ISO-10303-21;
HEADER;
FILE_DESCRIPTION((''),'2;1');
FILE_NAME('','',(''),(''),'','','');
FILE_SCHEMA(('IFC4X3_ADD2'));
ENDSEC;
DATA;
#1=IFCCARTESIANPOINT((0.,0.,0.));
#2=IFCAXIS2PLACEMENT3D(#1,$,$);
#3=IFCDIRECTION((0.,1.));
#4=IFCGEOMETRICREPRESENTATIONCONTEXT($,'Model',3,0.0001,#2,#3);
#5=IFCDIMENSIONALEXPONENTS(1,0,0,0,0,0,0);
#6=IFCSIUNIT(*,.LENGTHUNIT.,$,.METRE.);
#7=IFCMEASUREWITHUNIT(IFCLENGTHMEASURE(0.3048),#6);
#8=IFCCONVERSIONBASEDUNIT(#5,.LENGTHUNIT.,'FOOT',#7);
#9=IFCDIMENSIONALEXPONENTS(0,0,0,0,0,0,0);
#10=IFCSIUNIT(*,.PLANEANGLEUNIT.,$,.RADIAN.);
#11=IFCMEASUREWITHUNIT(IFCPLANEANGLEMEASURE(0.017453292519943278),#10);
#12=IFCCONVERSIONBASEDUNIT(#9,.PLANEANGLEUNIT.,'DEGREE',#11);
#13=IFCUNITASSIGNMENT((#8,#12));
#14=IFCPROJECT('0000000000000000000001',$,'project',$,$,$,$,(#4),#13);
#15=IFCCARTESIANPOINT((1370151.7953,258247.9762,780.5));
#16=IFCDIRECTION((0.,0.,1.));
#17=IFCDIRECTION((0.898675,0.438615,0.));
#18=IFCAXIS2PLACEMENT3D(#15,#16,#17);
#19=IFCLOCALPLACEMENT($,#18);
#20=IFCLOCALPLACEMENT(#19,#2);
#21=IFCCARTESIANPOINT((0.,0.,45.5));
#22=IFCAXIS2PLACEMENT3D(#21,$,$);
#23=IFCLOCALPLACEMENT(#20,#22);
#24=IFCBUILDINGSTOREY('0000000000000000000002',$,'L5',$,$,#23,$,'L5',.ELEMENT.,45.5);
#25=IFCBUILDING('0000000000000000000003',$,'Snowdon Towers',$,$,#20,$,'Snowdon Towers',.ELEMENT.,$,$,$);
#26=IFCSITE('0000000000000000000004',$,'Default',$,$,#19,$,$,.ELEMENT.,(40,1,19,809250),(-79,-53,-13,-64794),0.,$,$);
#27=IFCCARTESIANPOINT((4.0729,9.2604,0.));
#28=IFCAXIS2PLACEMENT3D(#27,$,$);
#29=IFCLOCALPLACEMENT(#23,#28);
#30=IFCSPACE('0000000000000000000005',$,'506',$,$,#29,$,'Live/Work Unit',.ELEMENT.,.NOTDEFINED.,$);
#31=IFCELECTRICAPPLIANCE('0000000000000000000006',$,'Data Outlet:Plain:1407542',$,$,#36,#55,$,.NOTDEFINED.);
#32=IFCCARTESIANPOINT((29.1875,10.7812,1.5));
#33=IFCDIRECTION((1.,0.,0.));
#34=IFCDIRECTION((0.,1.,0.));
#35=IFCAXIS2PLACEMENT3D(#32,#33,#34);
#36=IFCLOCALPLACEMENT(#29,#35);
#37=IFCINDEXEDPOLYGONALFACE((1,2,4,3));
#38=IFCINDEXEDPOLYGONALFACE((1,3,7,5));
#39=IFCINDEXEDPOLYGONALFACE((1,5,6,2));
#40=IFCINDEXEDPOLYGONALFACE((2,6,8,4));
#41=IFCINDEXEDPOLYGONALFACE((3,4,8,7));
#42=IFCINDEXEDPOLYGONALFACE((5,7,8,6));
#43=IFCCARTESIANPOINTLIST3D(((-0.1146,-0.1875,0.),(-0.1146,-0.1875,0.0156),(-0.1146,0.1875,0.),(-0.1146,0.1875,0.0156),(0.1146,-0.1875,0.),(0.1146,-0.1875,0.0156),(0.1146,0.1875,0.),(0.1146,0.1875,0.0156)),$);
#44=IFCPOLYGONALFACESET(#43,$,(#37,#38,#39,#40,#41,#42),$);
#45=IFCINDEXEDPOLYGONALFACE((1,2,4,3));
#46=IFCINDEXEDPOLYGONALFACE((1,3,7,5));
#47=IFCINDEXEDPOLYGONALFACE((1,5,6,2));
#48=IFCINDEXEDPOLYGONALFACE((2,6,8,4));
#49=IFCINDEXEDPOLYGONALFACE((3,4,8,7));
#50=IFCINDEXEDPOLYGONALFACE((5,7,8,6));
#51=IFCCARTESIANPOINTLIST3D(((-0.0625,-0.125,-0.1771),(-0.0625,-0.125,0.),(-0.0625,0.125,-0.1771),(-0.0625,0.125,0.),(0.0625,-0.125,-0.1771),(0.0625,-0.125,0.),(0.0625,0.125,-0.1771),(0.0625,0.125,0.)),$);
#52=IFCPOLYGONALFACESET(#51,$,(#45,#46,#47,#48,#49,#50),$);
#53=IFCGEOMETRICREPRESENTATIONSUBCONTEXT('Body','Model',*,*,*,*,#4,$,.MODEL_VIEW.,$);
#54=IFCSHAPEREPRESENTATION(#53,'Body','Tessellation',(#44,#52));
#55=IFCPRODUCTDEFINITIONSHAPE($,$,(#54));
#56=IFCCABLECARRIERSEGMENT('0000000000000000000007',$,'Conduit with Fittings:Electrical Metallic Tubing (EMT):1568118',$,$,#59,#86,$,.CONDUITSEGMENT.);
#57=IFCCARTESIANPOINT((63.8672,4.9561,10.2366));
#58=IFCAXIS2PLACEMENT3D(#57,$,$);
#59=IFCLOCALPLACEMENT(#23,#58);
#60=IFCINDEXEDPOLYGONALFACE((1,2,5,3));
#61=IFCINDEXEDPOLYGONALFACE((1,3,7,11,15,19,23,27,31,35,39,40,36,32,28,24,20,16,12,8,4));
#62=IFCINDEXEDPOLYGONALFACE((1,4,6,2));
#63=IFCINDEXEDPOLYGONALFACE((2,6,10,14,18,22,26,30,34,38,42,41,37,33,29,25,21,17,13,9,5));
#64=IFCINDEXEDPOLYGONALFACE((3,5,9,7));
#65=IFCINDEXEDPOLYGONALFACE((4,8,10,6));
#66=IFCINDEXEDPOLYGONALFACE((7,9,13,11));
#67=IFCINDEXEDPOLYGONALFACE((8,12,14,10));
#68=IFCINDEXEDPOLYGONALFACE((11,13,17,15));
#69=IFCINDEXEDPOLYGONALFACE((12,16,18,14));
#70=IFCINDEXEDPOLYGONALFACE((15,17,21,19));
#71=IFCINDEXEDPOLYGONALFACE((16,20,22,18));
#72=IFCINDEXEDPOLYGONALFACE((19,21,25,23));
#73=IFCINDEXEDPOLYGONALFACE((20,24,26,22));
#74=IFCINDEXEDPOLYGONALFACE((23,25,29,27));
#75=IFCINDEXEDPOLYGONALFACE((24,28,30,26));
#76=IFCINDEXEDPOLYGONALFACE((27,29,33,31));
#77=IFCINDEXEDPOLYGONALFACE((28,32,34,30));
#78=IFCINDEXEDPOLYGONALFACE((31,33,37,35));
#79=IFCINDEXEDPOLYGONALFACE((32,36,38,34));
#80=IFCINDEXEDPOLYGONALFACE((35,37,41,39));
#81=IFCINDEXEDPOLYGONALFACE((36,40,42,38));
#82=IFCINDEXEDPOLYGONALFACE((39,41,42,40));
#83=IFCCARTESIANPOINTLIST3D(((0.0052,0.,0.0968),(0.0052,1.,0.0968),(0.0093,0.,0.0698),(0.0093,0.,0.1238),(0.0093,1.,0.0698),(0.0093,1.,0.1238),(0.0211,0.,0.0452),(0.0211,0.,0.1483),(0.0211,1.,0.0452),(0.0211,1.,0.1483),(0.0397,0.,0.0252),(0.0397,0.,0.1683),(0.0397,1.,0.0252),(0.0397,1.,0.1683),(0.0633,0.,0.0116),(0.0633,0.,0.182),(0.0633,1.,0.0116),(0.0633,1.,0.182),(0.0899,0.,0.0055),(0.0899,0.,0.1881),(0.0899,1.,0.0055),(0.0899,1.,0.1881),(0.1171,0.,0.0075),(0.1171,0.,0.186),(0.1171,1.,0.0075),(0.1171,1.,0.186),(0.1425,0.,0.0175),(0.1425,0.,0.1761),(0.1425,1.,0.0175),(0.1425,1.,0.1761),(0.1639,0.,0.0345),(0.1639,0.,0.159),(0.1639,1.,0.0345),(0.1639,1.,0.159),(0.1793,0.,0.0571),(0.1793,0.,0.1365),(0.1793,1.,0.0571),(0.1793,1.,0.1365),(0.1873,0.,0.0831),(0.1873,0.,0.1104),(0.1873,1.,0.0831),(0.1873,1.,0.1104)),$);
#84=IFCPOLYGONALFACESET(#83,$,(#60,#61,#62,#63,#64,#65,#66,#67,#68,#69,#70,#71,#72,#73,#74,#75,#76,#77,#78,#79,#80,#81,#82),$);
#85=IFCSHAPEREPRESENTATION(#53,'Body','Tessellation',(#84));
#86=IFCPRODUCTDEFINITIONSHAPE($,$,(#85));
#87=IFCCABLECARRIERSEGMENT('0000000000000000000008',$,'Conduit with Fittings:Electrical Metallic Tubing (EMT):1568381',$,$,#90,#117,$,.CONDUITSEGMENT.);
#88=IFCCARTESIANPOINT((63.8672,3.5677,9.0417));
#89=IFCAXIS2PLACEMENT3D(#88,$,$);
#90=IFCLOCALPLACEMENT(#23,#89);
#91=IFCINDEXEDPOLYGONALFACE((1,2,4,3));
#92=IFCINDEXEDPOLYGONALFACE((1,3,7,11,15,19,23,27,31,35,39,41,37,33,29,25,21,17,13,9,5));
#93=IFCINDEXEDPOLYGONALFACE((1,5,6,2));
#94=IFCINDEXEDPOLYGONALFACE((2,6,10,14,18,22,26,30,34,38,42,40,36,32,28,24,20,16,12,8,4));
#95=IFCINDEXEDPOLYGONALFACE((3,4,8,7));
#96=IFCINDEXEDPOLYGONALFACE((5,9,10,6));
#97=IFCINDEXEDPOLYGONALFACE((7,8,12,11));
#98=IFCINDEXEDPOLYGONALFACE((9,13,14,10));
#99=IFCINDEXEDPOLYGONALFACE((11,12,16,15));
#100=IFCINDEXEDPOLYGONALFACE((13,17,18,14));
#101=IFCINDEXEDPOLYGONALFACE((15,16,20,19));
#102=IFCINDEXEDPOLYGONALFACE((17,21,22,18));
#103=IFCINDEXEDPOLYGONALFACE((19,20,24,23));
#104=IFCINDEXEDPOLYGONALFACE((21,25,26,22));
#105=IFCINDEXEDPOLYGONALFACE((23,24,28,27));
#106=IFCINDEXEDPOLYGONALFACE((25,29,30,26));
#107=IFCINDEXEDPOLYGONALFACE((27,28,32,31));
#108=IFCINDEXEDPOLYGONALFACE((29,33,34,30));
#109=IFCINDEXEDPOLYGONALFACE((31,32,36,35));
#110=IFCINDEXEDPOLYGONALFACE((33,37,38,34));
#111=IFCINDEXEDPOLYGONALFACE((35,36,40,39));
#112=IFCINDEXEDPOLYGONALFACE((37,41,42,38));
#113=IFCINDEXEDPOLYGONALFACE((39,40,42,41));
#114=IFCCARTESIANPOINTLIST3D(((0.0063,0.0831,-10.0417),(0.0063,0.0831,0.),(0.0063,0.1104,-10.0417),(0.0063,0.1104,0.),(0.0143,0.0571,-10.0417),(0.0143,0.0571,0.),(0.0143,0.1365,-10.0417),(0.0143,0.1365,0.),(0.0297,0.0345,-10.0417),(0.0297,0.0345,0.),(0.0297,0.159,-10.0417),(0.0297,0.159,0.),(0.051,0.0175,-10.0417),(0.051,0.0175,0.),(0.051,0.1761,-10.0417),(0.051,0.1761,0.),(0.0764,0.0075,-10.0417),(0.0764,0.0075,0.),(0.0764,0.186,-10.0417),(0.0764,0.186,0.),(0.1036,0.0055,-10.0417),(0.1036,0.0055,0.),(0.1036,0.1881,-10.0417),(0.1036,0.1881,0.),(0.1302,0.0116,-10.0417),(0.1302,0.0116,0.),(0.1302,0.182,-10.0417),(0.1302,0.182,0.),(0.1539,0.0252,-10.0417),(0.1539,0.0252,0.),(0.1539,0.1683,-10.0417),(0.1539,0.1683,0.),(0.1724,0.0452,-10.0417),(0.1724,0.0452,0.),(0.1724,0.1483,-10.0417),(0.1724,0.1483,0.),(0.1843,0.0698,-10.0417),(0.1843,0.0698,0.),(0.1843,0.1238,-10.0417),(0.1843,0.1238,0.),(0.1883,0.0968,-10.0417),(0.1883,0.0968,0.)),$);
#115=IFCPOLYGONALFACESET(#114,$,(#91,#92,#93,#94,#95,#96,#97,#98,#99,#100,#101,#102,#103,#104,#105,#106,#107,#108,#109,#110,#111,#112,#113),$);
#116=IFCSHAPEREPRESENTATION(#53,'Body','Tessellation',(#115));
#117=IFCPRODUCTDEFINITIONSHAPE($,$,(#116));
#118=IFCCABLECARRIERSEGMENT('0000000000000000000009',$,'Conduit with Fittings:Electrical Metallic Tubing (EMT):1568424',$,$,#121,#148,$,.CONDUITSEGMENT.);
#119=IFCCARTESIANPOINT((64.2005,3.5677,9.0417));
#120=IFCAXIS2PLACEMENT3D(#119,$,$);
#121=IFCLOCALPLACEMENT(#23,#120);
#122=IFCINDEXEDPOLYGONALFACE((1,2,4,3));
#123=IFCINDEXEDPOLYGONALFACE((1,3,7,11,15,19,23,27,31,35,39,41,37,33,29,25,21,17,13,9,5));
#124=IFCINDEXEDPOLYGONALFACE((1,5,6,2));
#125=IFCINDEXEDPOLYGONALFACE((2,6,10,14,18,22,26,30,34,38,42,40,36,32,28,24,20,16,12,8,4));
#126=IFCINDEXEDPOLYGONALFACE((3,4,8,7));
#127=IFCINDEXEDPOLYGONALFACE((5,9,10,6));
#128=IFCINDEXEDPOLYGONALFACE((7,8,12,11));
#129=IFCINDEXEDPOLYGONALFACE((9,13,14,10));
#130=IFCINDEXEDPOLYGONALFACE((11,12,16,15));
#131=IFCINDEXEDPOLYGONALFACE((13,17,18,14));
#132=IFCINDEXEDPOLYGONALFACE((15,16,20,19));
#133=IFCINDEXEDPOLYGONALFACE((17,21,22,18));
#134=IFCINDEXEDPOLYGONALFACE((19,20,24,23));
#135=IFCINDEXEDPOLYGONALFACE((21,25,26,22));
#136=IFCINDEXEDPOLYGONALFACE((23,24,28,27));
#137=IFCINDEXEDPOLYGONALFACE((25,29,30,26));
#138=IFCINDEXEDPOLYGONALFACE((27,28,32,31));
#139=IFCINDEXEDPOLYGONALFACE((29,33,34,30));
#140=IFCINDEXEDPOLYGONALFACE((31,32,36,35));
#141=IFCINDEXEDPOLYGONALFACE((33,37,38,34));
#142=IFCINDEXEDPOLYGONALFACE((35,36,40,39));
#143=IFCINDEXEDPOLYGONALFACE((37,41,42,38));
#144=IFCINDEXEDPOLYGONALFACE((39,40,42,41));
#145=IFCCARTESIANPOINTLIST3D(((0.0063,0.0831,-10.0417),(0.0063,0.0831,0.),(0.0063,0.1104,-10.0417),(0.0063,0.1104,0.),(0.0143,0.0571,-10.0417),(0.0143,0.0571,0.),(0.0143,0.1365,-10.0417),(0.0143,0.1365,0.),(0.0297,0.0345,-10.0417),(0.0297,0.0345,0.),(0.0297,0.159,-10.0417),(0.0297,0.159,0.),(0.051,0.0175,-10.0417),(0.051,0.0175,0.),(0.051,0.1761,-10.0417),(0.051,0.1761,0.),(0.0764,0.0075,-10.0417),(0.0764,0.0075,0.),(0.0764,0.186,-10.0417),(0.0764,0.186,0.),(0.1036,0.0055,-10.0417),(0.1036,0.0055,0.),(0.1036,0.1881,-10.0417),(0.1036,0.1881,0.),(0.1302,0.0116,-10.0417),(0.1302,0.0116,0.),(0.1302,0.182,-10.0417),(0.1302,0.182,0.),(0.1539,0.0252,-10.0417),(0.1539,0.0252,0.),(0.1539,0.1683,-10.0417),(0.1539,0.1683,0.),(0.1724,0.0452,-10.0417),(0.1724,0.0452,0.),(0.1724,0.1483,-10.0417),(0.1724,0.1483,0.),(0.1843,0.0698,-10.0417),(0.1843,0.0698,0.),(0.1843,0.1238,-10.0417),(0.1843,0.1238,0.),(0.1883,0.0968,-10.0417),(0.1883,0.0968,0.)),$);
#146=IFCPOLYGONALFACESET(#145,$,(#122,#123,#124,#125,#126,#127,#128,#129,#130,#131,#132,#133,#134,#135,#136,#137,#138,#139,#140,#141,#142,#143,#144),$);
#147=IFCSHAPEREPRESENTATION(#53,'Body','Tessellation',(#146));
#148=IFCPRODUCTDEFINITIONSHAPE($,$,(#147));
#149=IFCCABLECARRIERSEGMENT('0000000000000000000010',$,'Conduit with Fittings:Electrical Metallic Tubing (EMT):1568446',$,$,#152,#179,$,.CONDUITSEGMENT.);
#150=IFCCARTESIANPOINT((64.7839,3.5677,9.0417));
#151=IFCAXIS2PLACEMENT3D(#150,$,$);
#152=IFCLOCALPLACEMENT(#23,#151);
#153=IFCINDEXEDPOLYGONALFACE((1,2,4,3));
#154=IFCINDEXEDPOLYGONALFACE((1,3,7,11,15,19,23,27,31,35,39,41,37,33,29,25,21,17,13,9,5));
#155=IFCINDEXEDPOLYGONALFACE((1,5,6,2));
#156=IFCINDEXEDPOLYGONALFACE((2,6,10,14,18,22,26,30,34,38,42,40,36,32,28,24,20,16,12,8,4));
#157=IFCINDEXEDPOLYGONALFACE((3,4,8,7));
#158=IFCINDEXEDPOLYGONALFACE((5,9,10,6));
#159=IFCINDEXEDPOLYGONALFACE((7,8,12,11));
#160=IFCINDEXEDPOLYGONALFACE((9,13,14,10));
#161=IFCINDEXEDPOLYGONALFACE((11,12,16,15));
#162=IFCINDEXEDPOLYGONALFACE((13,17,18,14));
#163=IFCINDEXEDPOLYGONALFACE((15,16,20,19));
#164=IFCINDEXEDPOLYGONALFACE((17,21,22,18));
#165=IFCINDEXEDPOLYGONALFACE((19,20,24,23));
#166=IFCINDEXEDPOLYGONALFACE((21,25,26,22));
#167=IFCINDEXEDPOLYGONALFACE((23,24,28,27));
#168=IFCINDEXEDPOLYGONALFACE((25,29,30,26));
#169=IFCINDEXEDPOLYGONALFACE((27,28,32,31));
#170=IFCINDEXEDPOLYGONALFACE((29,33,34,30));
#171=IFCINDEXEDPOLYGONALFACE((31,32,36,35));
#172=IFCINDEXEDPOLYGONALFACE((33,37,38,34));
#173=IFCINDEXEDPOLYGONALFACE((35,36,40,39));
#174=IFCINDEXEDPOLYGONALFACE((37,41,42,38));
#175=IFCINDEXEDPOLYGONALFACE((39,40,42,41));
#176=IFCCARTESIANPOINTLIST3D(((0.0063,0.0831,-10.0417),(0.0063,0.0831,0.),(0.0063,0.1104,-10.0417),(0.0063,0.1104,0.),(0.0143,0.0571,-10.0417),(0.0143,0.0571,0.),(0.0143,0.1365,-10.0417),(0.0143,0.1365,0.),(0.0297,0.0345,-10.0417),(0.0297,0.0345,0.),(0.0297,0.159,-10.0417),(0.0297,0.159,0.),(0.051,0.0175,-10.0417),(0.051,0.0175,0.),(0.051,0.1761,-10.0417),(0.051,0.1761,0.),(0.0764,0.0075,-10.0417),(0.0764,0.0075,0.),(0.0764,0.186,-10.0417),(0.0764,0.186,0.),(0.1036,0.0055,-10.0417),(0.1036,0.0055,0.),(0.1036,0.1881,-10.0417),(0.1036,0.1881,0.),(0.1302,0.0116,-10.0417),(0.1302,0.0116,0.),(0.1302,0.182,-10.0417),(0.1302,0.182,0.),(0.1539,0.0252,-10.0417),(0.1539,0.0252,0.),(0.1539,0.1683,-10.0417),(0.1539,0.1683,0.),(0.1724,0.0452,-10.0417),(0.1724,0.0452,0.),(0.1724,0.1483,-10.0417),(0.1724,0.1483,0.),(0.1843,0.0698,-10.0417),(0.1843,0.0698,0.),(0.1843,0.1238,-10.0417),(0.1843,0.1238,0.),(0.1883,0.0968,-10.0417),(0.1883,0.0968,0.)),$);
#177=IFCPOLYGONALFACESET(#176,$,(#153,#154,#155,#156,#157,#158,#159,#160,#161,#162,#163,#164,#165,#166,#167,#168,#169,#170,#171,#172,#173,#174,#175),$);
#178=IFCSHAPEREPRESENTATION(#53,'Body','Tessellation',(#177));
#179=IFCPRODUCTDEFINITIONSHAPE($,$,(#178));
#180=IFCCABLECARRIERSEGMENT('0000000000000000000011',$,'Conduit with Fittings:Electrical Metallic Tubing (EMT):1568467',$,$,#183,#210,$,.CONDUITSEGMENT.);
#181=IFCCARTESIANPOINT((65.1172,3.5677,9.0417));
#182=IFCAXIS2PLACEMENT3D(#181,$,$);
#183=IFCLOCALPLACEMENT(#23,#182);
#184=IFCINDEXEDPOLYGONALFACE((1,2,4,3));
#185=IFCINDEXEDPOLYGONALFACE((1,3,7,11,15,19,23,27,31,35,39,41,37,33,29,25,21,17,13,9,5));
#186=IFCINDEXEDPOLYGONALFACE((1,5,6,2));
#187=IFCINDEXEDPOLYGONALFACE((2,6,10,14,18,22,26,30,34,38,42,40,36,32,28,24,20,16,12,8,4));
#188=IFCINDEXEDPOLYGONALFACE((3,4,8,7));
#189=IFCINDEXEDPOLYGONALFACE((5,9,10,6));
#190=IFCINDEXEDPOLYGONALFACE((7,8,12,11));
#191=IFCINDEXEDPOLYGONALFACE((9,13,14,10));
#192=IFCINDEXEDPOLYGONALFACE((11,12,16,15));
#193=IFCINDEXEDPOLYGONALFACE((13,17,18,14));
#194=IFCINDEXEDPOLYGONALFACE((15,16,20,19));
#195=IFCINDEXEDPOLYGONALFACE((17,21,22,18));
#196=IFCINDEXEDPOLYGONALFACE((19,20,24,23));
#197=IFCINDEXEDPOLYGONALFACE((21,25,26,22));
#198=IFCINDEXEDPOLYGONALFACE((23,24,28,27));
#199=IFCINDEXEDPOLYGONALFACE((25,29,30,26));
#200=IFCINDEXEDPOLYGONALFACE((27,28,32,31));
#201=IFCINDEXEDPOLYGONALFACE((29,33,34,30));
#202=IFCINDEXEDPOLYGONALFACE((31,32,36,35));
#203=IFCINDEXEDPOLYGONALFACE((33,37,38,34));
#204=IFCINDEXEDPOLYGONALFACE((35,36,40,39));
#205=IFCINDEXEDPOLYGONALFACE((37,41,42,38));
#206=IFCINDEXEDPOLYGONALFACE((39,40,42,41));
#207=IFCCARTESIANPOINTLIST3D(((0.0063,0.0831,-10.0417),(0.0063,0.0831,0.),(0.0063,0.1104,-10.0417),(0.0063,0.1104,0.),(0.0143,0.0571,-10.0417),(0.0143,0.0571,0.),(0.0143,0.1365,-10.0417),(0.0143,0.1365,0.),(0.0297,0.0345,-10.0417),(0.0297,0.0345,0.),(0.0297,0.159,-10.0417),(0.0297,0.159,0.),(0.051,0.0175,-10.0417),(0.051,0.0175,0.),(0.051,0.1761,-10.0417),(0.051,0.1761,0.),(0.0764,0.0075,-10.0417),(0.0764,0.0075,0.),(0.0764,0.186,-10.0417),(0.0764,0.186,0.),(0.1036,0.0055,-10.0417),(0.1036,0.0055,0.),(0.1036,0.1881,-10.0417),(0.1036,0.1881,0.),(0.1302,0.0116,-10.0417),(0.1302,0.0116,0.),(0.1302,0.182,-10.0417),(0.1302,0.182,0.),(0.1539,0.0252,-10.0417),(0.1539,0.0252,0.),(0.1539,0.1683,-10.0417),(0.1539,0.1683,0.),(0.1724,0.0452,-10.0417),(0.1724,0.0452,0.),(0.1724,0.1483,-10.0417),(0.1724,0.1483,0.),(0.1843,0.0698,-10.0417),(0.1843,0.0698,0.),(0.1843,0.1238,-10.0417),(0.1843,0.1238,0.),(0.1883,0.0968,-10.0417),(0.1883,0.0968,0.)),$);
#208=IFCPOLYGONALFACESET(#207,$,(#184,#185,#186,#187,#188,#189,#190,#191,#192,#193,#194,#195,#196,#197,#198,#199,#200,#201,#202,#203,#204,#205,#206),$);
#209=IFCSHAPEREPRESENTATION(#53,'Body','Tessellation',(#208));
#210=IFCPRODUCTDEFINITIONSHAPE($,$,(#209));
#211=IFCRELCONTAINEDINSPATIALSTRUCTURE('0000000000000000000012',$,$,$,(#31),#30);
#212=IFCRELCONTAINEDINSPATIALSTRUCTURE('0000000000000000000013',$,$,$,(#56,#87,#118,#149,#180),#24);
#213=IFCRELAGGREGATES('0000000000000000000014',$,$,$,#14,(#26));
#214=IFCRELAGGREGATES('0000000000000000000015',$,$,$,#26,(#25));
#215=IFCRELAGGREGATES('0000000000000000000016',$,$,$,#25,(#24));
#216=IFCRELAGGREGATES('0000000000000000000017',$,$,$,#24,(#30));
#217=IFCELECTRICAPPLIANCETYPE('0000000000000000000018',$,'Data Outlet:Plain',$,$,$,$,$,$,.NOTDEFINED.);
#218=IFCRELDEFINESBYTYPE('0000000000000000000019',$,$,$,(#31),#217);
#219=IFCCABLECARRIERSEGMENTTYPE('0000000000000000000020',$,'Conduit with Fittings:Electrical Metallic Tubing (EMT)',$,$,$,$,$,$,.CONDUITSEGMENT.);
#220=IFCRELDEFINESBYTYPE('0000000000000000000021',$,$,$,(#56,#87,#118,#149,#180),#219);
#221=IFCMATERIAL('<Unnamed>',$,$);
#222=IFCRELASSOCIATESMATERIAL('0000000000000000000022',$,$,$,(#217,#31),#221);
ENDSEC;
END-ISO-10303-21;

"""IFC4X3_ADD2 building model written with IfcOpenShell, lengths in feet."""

from ifc_helpers import new_model, entity, si_unit, converted_unit, direction, frame, frame_2d, origin, origin_2d_with_axis, place, context, subcontext, project, spatial, rectangle, circle, extrude, source, transform, mapped, material, type_object, type_shapes, element, save


model = new_model("IFC4X3_ADD2")

# Units and contexts
model_context = context("Model", 3, precision=0.0001, world=origin(), true_north=direction((0.0, 1.0)))
body_context = subcontext(model_context, "Body", "Model", "MODEL_VIEW")
ifc_project = project(units=[converted_unit("LENGTHUNIT", "FOOT", entity("IfcLengthMeasure", 0.3048), si_unit("LENGTHUNIT", "METRE"), dimensions=[1, 0, 0, 0, 0, 0, 0]), converted_unit("PLANEANGLEUNIT", "DEGREE", entity("IfcPlaneAngleMeasure", 0.017453292519943278), si_unit("PLANEANGLEUNIT", "RADIAN"), dimensions=[0, 0, 0, 0, 0, 0, 0])], contexts=[model_context])

# Site, building, storey, space
site_placement = place(None, frame((1370151.7953, 258247.9762, 780.5), z_axis=(0.0, 0.0, 1.0), x_axis=(0.898675, 0.438615, 0.0)))
site = spatial("IfcSite", under=ifc_project, at=site_placement, Name="Default", CompositionType="ELEMENT", RefLatitude=(40, 1, 19, 809250), RefLongitude=(-79, -53, -13, -64794), RefElevation=0.0)
building_placement = place(site_placement, origin())
building = spatial("IfcBuilding", under=site, at=building_placement, Name="Snowdon Towers", LongName="Snowdon Towers", CompositionType="ELEMENT")
storey_placement = place(building_placement, frame((0.0, 0.0, 45.5)))
storey = spatial("IfcBuildingStorey", under=building, at=storey_placement, Name="L5", LongName="L5", CompositionType="ELEMENT", Elevation=45.5)
space_1_placement = place(storey_placement, frame((4.0729, 9.2604, 0.0)))
space_1 = spatial("IfcSpace", under=storey, at=space_1_placement, Name="506", LongName="Live/Work Unit", CompositionType="ELEMENT", PredefinedType="NOTDEFINED")

# Electric appliance
ifc_material_1 = material(Name="<Unnamed>")
electric_appliance_type = type_object("IfcElectricApplianceType", Name="Data Outlet:Plain", PredefinedType="NOTDEFINED", material=ifc_material_1)
shared_shape_1 = source(origin(), body_context, "Body", "SweptSolid", [
    extrude(rectangle(XDim=0.2292, YDim=0.375, at=frame_2d((0.0, 0.0), x_axis=(1.0, 0.0))), frame((0.0, 0.0, 0.0), z_axis=(0.0, 0.0, 1.0), x_axis=(-1.0, 0.0, 0.0)), (0.0, 0.0, 1.0), 0.0156),
    extrude(rectangle(XDim=0.125, YDim=0.25, at=frame_2d((0.0, 0.0), x_axis=(1.0, 0.0))), frame((0.0, 0.0, -0.1771), z_axis=(0.0, 0.0, 1.0), x_axis=(-1.0, 0.0, 0.0)), (0.0, 0.0, 1.0), 0.1771),
])
type_shapes(electric_appliance_type, [shared_shape_1])
electric_appliance_placement = place(space_1_placement, frame((29.1875, 10.7812, 1.5), z_axis=(1.0, 0.0, 0.0), x_axis=(0.0, 1.0, 0.0)))
element("IfcElectricAppliance", 1, at=electric_appliance_placement, inside=space_1, type_object=electric_appliance_type, material=ifc_material_1, Name="Data Outlet:Plain:1407542", PredefinedType="NOTDEFINED", context=body_context, shape_type="MappedRepresentation", body=[
    mapped(shared_shape_1, transform((0.0, 0.0, 0.0), scale=1.0)),
])

# Cable carrier segments
cable_carrier_segment_type = type_object("IfcCableCarrierSegmentType", Name="Conduit with Fittings:Electrical Metallic Tubing (EMT)", PredefinedType="CONDUITSEGMENT")
cable_carrier_segment_1_placement = place(storey_placement, frame((63.8672, 4.9561, 10.2366)))
element("IfcCableCarrierSegment", 2, at=cable_carrier_segment_1_placement, inside=storey, type_object=cable_carrier_segment_type, Name="Conduit with Fittings:Electrical Metallic Tubing (EMT):1568118", PredefinedType="CONDUITSEGMENT", context=body_context, shape_type="SweptSolid", body=[
    extrude(circle(Radius=0.0915, at=origin_2d_with_axis()), frame((0.0968, 0.0, 0.0968), z_axis=(0.0, 1.0, 0.0), x_axis=(-1.0, 0.0, 0.0)), (0.0, 0.0, 1.0), 1.0),
])
cable_carrier_segment_2_placement = place(storey_placement, frame((63.8672, 3.5677, 9.0417)))
element("IfcCableCarrierSegment", 3, at=cable_carrier_segment_2_placement, inside=storey, type_object=cable_carrier_segment_type, Name="Conduit with Fittings:Electrical Metallic Tubing (EMT):1568381", PredefinedType="CONDUITSEGMENT", context=body_context, shape_type="SweptSolid", body=[
    extrude(circle(Radius=0.0915, at=frame_2d((0.0, 0.0), x_axis=(1.0, 0.0))), frame((0.0968, 0.0968, -10.0417)), (0.0, 0.0, 1.0), 10.0417),
])
cable_carrier_segment_3_placement = place(storey_placement, frame((64.2005, 3.5677, 9.0417)))
element("IfcCableCarrierSegment", 4, at=cable_carrier_segment_3_placement, inside=storey, type_object=cable_carrier_segment_type, Name="Conduit with Fittings:Electrical Metallic Tubing (EMT):1568424", PredefinedType="CONDUITSEGMENT", context=body_context, shape_type="SweptSolid", body=[
    extrude(circle(Radius=0.0915, at=frame_2d((0.0, 0.0), x_axis=(1.0, 0.0))), frame((0.0968, 0.0968, -10.0417)), (0.0, 0.0, 1.0), 10.0417),
])
cable_carrier_segment_4_placement = place(storey_placement, frame((64.7839, 3.5677, 9.0417)))
element("IfcCableCarrierSegment", 5, at=cable_carrier_segment_4_placement, inside=storey, type_object=cable_carrier_segment_type, Name="Conduit with Fittings:Electrical Metallic Tubing (EMT):1568446", PredefinedType="CONDUITSEGMENT", context=body_context, shape_type="SweptSolid", body=[
    extrude(circle(Radius=0.0915, at=origin_2d_with_axis()), frame((0.0968, 0.0968, -10.0417)), (0.0, 0.0, 1.0), 10.0417),
])
cable_carrier_segment_5_placement = place(storey_placement, frame((65.1172, 3.5677, 9.0417)))
element("IfcCableCarrierSegment", 6, at=cable_carrier_segment_5_placement, inside=storey, type_object=cable_carrier_segment_type, Name="Conduit with Fittings:Electrical Metallic Tubing (EMT):1568467", PredefinedType="CONDUITSEGMENT", context=body_context, shape_type="SweptSolid", body=[
    extrude(circle(Radius=0.0915, at=frame_2d((0.0, 0.0), x_axis=(1.0, 0.0))), frame((0.0968, 0.0968, -10.0417)), (0.0, 0.0, 1.0), 10.0417),
])

save(model, "model.ifc")
